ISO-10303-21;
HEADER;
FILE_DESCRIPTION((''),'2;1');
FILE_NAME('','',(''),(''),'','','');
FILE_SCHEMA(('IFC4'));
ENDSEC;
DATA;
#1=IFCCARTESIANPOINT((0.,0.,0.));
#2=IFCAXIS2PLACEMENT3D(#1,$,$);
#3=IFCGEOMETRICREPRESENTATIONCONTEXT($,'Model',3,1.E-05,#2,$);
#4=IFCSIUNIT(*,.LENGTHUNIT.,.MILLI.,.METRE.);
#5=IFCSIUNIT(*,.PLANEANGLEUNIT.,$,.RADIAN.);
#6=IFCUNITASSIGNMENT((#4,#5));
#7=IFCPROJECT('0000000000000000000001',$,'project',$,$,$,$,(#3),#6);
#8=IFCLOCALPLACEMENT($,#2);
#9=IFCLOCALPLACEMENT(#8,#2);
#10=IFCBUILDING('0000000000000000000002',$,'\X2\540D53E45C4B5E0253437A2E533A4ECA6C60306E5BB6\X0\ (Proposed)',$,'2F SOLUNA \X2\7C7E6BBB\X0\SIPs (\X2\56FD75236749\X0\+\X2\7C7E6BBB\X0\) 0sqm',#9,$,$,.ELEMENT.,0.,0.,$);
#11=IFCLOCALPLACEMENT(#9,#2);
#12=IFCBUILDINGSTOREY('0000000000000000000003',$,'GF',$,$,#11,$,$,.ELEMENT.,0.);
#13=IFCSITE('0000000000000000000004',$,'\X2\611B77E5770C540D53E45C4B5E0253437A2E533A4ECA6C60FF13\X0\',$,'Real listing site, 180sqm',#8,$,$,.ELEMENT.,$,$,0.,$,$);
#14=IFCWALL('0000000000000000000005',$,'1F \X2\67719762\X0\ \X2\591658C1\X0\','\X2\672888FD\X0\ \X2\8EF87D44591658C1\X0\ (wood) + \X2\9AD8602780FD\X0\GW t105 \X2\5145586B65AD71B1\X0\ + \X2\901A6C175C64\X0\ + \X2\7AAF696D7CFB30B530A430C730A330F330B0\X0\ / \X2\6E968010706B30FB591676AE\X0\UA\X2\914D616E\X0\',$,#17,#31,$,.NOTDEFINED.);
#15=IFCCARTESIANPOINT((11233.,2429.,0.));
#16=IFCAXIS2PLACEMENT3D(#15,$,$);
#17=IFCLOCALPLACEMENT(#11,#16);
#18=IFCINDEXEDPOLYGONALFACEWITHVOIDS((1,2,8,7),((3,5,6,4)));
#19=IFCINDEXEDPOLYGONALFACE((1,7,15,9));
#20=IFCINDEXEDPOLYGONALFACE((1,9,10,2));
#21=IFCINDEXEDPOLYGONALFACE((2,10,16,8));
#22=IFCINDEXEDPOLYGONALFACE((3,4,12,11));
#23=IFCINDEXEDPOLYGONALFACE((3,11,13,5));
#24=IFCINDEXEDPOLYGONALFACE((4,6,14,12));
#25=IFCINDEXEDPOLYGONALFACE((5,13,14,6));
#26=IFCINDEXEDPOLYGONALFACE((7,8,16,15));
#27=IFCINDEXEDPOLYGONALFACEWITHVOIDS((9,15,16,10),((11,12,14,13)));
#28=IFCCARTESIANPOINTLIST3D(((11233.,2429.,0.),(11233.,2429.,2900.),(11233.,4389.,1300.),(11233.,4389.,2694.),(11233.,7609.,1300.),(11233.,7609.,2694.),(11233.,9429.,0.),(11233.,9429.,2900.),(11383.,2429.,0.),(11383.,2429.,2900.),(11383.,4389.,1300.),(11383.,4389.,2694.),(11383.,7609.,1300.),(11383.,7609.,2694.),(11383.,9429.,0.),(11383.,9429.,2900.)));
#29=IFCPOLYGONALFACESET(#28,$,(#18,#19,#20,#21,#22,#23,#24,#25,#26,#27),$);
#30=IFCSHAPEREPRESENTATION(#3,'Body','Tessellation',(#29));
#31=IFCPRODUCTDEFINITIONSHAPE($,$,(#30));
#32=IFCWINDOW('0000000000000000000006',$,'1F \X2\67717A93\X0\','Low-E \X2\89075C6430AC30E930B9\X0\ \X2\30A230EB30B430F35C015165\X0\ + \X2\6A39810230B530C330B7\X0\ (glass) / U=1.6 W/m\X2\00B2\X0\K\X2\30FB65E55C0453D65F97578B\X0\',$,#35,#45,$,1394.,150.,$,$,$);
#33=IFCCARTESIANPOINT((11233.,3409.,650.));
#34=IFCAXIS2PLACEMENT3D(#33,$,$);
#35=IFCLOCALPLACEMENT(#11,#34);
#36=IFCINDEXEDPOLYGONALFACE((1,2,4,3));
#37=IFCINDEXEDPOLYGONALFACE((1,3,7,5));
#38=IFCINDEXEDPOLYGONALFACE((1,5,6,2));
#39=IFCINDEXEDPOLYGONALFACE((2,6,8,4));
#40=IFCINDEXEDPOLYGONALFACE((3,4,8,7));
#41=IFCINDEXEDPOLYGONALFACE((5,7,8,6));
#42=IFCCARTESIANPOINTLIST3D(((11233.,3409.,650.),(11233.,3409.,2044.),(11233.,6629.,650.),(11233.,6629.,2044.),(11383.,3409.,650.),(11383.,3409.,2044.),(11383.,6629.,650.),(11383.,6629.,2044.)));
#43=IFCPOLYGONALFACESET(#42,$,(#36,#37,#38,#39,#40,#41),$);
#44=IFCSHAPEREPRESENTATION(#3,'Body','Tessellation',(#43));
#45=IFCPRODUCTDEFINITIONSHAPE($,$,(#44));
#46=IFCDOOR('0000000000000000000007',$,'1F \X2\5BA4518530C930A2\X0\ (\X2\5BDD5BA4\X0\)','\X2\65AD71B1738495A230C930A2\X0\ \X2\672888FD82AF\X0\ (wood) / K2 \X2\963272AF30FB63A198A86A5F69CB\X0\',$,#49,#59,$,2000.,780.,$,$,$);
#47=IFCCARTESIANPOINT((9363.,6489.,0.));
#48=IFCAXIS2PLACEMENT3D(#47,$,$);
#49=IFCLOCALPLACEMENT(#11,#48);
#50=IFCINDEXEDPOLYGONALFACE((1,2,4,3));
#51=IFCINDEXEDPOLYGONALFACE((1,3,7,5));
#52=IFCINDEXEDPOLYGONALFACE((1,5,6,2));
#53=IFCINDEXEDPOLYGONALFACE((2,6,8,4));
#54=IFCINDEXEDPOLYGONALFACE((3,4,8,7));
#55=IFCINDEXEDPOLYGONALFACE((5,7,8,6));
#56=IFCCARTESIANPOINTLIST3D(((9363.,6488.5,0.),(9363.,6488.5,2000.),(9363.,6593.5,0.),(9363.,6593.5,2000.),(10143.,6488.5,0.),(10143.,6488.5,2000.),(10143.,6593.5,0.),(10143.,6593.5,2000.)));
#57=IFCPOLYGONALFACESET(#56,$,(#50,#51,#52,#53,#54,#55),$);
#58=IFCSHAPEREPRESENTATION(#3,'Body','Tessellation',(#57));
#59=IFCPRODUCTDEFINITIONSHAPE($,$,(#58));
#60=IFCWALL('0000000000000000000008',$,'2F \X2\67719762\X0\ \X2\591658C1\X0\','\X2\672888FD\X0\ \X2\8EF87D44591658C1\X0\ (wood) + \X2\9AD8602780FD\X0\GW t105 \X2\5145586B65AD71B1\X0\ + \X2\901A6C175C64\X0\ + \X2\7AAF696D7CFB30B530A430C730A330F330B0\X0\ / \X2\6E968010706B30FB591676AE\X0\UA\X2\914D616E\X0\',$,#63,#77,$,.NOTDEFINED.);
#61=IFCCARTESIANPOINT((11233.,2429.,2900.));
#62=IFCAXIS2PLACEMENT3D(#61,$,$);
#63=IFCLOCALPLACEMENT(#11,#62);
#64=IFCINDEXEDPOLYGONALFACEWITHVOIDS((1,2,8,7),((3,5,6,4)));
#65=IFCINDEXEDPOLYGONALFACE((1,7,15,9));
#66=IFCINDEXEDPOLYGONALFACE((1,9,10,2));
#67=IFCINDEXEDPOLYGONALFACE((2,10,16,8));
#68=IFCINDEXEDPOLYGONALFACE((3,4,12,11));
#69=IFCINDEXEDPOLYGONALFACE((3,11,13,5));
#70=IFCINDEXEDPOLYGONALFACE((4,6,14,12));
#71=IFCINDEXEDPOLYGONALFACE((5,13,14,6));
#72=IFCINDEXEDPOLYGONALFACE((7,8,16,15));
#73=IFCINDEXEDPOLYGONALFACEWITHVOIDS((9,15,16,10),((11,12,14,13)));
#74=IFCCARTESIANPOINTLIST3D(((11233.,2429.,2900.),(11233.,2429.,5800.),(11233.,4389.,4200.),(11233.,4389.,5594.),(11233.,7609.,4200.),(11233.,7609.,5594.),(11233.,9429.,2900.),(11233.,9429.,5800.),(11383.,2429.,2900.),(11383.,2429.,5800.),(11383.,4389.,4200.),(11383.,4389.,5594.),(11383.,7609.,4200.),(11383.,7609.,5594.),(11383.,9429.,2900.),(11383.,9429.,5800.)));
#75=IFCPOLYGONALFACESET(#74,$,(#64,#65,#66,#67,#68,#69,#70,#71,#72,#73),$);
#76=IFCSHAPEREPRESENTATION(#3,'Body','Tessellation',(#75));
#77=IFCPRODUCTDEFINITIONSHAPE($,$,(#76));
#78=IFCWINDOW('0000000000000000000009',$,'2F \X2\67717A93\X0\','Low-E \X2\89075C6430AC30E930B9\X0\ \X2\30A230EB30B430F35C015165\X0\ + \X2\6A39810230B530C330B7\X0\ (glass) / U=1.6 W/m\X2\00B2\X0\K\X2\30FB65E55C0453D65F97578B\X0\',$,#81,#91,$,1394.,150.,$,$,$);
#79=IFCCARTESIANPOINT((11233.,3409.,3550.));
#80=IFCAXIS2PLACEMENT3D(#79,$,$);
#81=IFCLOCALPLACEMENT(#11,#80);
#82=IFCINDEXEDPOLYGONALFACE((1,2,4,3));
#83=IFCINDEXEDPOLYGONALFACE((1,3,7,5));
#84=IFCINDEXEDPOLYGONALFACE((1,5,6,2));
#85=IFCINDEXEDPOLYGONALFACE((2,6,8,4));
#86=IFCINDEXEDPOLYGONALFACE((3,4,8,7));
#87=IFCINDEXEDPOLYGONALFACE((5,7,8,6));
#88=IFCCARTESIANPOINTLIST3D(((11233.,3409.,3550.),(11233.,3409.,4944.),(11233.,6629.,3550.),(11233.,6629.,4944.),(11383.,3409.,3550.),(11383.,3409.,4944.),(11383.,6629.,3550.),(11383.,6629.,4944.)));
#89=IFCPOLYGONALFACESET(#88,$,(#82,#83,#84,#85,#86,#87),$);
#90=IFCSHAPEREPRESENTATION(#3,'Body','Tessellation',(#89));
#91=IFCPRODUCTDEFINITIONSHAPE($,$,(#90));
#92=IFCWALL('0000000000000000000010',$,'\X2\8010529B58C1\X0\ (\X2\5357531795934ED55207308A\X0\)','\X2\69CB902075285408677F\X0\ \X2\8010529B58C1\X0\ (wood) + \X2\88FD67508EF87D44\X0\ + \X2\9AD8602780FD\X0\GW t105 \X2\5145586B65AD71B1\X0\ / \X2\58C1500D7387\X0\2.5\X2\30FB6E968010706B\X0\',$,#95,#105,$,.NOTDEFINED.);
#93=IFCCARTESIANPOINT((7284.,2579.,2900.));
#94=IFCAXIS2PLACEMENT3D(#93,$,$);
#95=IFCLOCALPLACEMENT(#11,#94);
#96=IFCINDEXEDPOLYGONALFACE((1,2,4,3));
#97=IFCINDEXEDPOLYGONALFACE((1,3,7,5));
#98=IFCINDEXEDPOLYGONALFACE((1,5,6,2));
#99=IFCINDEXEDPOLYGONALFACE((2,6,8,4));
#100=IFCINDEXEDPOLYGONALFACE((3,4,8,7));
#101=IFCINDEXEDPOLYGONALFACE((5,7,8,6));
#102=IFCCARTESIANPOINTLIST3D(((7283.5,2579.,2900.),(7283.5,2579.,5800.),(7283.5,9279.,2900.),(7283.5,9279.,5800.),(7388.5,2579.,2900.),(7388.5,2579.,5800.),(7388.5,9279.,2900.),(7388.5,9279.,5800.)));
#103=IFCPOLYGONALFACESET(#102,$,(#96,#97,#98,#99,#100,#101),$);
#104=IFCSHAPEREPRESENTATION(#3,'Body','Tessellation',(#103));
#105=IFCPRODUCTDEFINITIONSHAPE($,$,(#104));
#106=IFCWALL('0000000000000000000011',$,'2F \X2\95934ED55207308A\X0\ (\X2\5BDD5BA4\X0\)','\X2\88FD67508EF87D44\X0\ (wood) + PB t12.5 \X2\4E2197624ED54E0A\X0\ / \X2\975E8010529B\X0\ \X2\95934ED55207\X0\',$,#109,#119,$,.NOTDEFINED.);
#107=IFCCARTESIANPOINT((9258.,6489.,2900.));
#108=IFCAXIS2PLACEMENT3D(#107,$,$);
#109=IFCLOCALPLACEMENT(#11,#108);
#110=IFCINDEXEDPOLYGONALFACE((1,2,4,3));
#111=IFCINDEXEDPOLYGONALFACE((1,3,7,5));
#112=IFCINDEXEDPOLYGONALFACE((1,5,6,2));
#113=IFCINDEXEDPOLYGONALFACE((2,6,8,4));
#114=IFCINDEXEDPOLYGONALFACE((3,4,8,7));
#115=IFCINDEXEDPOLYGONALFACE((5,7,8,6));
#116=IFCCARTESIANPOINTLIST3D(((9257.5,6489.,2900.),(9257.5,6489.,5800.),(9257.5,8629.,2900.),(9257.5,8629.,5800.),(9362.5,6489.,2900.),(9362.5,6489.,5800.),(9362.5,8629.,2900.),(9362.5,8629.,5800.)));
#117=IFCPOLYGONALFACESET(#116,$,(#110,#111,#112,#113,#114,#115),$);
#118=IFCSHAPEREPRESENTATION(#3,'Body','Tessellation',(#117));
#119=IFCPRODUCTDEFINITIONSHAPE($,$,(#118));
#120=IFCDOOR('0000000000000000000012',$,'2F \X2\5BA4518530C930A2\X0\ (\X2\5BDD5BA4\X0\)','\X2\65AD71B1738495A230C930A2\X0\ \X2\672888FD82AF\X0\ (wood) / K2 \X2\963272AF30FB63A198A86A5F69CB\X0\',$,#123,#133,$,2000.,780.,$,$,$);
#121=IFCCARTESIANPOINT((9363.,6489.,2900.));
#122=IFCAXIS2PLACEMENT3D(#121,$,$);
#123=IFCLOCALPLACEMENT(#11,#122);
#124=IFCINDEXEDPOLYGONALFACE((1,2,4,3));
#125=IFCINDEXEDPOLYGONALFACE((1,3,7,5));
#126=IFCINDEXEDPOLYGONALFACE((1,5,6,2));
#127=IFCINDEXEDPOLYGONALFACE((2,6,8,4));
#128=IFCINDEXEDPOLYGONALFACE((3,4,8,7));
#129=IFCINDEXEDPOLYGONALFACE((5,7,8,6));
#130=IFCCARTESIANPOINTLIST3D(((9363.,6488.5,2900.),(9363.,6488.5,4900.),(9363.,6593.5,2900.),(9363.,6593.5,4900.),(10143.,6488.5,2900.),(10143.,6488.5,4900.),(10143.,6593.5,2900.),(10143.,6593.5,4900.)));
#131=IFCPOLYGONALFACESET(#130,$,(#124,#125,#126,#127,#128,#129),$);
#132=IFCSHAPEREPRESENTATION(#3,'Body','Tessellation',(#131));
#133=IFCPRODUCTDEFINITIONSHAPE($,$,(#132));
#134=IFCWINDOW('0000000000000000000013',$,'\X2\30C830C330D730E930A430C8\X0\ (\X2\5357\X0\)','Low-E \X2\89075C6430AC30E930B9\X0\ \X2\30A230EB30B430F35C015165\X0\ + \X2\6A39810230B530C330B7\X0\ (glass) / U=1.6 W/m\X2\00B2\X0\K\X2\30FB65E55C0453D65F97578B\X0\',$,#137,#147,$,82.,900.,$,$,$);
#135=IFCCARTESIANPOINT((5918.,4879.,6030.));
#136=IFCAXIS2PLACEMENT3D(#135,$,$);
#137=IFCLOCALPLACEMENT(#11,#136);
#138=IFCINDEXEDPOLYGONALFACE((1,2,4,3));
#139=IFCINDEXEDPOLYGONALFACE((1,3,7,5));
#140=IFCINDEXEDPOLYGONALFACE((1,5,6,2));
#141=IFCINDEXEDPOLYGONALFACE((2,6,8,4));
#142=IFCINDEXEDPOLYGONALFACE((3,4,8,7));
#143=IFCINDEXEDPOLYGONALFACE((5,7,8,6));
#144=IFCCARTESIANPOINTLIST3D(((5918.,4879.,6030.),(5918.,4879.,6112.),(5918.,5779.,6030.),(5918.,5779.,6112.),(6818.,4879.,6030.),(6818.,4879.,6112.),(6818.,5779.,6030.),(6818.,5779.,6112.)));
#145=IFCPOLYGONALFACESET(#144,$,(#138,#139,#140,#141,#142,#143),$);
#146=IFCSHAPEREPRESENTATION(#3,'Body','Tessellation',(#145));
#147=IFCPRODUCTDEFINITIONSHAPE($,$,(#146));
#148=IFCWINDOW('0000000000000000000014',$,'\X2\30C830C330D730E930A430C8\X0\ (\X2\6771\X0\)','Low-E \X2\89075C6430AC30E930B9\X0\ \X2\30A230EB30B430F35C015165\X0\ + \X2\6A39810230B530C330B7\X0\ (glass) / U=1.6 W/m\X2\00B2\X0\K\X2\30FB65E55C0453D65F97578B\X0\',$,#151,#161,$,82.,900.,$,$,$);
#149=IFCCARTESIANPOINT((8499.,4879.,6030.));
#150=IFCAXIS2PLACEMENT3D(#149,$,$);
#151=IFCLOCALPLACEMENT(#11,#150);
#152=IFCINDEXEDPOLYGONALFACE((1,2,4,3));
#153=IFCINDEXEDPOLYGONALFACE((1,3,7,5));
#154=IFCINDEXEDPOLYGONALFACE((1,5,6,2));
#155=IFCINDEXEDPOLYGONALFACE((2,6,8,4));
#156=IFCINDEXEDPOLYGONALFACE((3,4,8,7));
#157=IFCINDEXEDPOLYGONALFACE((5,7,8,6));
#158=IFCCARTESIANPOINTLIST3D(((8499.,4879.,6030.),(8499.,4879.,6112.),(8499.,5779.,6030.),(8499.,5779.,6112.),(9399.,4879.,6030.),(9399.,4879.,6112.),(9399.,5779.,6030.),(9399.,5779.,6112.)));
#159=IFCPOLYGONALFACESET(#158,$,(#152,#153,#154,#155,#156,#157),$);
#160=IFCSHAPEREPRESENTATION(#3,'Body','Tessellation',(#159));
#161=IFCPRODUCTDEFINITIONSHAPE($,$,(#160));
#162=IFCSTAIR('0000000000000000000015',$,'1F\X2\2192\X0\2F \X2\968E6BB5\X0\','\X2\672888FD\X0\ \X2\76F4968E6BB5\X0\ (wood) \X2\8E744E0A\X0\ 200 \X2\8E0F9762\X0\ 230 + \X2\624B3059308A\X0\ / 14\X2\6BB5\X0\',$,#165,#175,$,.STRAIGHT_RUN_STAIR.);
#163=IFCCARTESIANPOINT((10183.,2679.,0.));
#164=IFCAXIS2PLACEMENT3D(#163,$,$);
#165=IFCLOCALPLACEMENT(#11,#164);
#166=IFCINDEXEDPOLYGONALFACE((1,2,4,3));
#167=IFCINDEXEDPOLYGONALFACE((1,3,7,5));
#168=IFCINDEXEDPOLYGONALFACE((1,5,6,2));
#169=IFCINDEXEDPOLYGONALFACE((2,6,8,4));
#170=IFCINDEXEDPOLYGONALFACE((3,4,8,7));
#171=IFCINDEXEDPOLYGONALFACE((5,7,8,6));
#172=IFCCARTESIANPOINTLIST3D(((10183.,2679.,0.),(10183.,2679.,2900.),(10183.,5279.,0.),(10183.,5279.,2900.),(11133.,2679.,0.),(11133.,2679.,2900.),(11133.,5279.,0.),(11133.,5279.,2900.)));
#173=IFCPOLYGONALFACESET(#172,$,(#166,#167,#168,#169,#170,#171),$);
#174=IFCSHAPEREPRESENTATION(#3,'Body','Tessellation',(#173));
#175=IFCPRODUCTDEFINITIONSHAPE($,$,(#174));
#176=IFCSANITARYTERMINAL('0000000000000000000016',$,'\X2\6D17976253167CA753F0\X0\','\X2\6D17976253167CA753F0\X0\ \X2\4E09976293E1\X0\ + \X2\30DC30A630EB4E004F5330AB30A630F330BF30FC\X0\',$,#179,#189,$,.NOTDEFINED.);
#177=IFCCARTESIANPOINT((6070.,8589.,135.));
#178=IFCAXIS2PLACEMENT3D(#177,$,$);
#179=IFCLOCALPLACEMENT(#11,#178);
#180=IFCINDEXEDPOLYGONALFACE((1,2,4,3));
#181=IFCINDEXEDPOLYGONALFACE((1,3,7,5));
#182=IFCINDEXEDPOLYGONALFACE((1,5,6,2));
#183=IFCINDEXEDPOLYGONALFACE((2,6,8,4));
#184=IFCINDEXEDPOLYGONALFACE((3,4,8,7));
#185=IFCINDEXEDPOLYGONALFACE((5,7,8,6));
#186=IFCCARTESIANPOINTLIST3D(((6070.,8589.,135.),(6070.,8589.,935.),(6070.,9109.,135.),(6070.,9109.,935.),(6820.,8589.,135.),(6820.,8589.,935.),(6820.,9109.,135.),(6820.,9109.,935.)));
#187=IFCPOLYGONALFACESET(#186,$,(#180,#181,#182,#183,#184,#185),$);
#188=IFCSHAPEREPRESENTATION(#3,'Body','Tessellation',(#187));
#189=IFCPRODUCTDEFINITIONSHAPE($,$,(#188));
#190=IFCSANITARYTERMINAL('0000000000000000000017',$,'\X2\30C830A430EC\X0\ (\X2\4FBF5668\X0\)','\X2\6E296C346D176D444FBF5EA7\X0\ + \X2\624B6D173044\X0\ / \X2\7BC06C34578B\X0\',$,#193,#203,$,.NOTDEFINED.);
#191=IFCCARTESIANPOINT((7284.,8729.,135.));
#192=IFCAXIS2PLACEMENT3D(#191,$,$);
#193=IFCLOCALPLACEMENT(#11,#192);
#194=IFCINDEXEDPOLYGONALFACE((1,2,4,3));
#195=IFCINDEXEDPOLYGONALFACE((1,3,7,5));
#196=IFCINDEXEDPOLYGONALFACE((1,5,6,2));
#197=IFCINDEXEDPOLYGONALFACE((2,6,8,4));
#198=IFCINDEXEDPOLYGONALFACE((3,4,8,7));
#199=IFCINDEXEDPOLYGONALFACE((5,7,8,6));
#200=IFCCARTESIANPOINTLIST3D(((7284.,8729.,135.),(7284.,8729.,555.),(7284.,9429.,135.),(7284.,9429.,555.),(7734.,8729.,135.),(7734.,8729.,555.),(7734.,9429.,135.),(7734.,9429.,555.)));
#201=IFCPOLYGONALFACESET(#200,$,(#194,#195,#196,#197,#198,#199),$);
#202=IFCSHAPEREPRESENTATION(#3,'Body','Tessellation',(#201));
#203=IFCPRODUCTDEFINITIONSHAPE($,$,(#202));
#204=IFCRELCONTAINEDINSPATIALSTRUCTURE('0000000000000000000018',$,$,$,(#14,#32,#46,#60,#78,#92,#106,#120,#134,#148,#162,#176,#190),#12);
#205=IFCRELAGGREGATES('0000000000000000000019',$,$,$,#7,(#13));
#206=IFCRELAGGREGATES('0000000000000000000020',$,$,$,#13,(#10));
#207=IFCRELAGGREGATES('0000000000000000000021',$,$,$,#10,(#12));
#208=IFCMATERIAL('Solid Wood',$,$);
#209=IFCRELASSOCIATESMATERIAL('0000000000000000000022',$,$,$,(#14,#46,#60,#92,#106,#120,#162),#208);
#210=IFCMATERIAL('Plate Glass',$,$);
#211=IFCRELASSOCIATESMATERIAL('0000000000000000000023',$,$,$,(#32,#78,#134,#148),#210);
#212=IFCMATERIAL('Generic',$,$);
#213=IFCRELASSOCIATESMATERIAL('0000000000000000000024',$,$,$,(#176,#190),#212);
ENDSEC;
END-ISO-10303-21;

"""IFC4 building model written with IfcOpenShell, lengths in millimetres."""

from ifc_helpers import new_model, si_unit, frame, frame_2d, origin, place, context, project, spatial, rectangle, extrude, material, element, fill, save


model = new_model("IFC4")

# Units and contexts
model_context = context("Model", 3, precision=1e-05, world=origin())
ifc_project = project(units=[si_unit("LENGTHUNIT", "METRE", prefix="MILLI"), si_unit("PLANEANGLEUNIT", "RADIAN")], contexts=[model_context])

# Site, building, storey
site_placement = place(None, origin())
site = spatial("IfcSite", under=ifc_project, at=site_placement, Name="愛知県名古屋市千種区今池３", ObjectType="Real listing site, 180sqm", CompositionType="ELEMENT", RefElevation=0.0)
building_placement = place(site_placement, origin())
building = spatial("IfcBuilding", under=site, at=building_placement, Name="名古屋市千種区今池の家 (Proposed)", ObjectType="2F SOLUNA 籾殻SIPs (国産杉+籾殻) 0sqm", CompositionType="ELEMENT", ElevationOfRefHeight=0.0, ElevationOfTerrain=0.0)
storey_placement = place(building_placement, origin())
storey = spatial("IfcBuildingStorey", under=building, at=storey_placement, Name="GF", CompositionType="ELEMENT", Elevation=0.0)

# Wall, opening, window
ifc_material_1 = material(Name="Solid Wood")
wall_1_placement = place(storey_placement, frame((11233.0, 2429.0, 0.0)))
wall_1 = element("IfcWall", 1, at=wall_1_placement, inside=storey, material=ifc_material_1, Name="1F 東面 外壁", Description="木製 軸組外壁 (wood) + 高性能GW t105 充填断熱 + 通気層 + 窯業系サイディング / 準耐火・外皮UA配慮", PredefinedType="NOTDEFINED", context=model_context, shape_type="SweptSolid", body=[
    extrude(rectangle(XDim=150.0, YDim=7000.0, at=frame_2d((75.0, 3500.0))), frame((11233.0, 2429.0, 0.0)), (0.0, 0.0, 1.0), 2900.0),
])
opening_1_placement = place(storey_placement, frame((11233.0, 3409.0, 650.0)))
opening_1 = element("IfcOpeningElement", 2, at=opening_1_placement, cuts=wall_1, PredefinedType="NOTDEFINED", context=model_context, shape_type="SweptSolid", body=[
    extrude(rectangle(XDim=150.0, YDim=3220.0, at=frame_2d((75.0, 1610.0))), frame((11233.0, 3409.0, 650.0)), (0.0, 0.0, 1.0), 1394.0),
])
ifc_material_2 = material(Name="Plate Glass")
window_1_placement = place(storey_placement, frame((11233.0, 3409.0, 650.0)))
window_1 = element("IfcWindow", 3, at=window_1_placement, inside=storey, material=ifc_material_2, Name="1F 東窓", Description="Low-E 複層ガラス アルゴン封入 + 樹脂サッシ (glass) / U=1.6 W/m²K・日射取得型", OverallHeight=1394.0, OverallWidth=150.0, context=model_context, shape_type="SweptSolid", body=[
    extrude(rectangle(XDim=150.0, YDim=3220.0, at=frame_2d((75.0, 1610.0))), frame((11233.0, 3409.0, 650.0)), (0.0, 0.0, 1.0), 1394.0),
])
fill(opening_1, window_1)

# Door
door_1_placement = place(storey_placement, frame((9363.0, 6489.0, 0.0)))
element("IfcDoor", 4, at=door_1_placement, inside=storey, material=ifc_material_1, Name="1F 室内ドア (寝室)", Description="断熱玄関ドア 木製芯 (wood) / K2 防犯・採風機構", OverallHeight=2000.0, OverallWidth=780.0, context=model_context, shape_type="SweptSolid", body=[
    extrude(rectangle(XDim=780.0, YDim=105.0, at=frame_2d((390.0, 52.0))), frame((9363.0, 6489.0, 0.0)), (0.0, 0.0, 1.0), 2000.0),
])

# Wall, opening, window
wall_2_placement = place(storey_placement, frame((11233.0, 2429.0, 2900.0)))
wall_2 = element("IfcWall", 5, at=wall_2_placement, inside=storey, material=ifc_material_1, Name="2F 東面 外壁", Description="木製 軸組外壁 (wood) + 高性能GW t105 充填断熱 + 通気層 + 窯業系サイディング / 準耐火・外皮UA配慮", PredefinedType="NOTDEFINED", context=model_context, shape_type="SweptSolid", body=[
    extrude(rectangle(XDim=150.0, YDim=7000.0, at=frame_2d((75.0, 3500.0))), frame((11233.0, 2429.0, 2900.0)), (0.0, 0.0, 1.0), 2900.0),
])
opening_2_placement = place(storey_placement, frame((11233.0, 3409.0, 3550.0)))
opening_2 = element("IfcOpeningElement", 6, at=opening_2_placement, cuts=wall_2, PredefinedType="NOTDEFINED", context=model_context, shape_type="SweptSolid", body=[
    extrude(rectangle(XDim=150.0, YDim=3220.0, at=frame_2d((75.0, 1610.0))), frame((11233.0, 3409.0, 3550.0)), (0.0, 0.0, 1.0), 1394.0),
])
window_2_placement = place(storey_placement, frame((11233.0, 3409.0, 3550.0)))
window_2 = element("IfcWindow", 7, at=window_2_placement, inside=storey, material=ifc_material_2, Name="2F 東窓", Description="Low-E 複層ガラス アルゴン封入 + 樹脂サッシ (glass) / U=1.6 W/m²K・日射取得型", OverallHeight=1394.0, OverallWidth=150.0, context=model_context, shape_type="SweptSolid", body=[
    extrude(rectangle(XDim=150.0, YDim=3220.0, at=frame_2d((75.0, 1610.0))), frame((11233.0, 3409.0, 3550.0)), (0.0, 0.0, 1.0), 1394.0),
])
fill(opening_2, window_2)

# Walls
wall_3_placement = place(storey_placement, frame((7284.0, 2579.0, 2900.0)))
element("IfcWall", 8, at=wall_3_placement, inside=storey, material=ifc_material_1, Name="耐力壁 (南北間仕切り)", Description="構造用合板 耐力壁 (wood) + 製材軸組 + 高性能GW t105 充填断熱 / 壁倍率2.5・準耐火", PredefinedType="NOTDEFINED", context=model_context, shape_type="SweptSolid", body=[
    extrude(rectangle(XDim=105.0, YDim=6700.0, at=frame_2d((52.0, 3350.0))), frame((7284.0, 2579.0, 2900.0)), (0.0, 0.0, 1.0), 2900.0),
])
wall_4_placement = place(storey_placement, frame((9258.0, 6489.0, 2900.0)))
element("IfcWall", 9, at=wall_4_placement, inside=storey, material=ifc_material_1, Name="2F 間仕切り (寝室)", Description="製材軸組 (wood) + PB t12.5 両面仕上 / 非耐力 間仕切", PredefinedType="NOTDEFINED", context=model_context, shape_type="SweptSolid", body=[
    extrude(rectangle(XDim=105.0, YDim=2140.0, at=frame_2d((52.0, 1070.0))), frame((9258.0, 6489.0, 2900.0)), (0.0, 0.0, 1.0), 2900.0),
])

# Door
door_2_placement = place(storey_placement, frame((9363.0, 6489.0, 2900.0)))
element("IfcDoor", 10, at=door_2_placement, inside=storey, material=ifc_material_1, Name="2F 室内ドア (寝室)", Description="断熱玄関ドア 木製芯 (wood) / K2 防犯・採風機構", OverallHeight=2000.0, OverallWidth=780.0, context=model_context, shape_type="SweptSolid", body=[
    extrude(rectangle(XDim=780.0, YDim=105.0, at=frame_2d((390.0, 52.0))), frame((9363.0, 6489.0, 2900.0)), (0.0, 0.0, 1.0), 2000.0),
])

# Windows
window_3_placement = place(storey_placement, frame((5918.0, 4879.0, 6030.0)))
element("IfcWindow", 11, at=window_3_placement, inside=storey, material=ifc_material_2, Name="トップライト (南)", Description="Low-E 複層ガラス アルゴン封入 + 樹脂サッシ (glass) / U=1.6 W/m²K・日射取得型", OverallHeight=82.0, OverallWidth=900.0, context=model_context, shape_type="SweptSolid", body=[
    extrude(rectangle(XDim=900.0, YDim=900.0, at=frame_2d((450.0, 450.0))), frame((5918.0, 4879.0, 6030.0)), (0.0, 0.0, 1.0), 82.0),
])
window_4_placement = place(storey_placement, frame((8499.0, 4879.0, 6030.0)))
element("IfcWindow", 12, at=window_4_placement, inside=storey, material=ifc_material_2, Name="トップライト (東)", Description="Low-E 複層ガラス アルゴン封入 + 樹脂サッシ (glass) / U=1.6 W/m²K・日射取得型", OverallHeight=82.0, OverallWidth=900.0, context=model_context, shape_type="SweptSolid", body=[
    extrude(rectangle(XDim=900.0, YDim=900.0, at=frame_2d((450.0, 450.0))), frame((8499.0, 4879.0, 6030.0)), (0.0, 0.0, 1.0), 82.0),
])

# Stair
stair_placement = place(storey_placement, frame((10183.0, 2679.0, 0.0)))
element("IfcStair", 13, at=stair_placement, inside=storey, material=ifc_material_1, Name="1F→2F 階段", Description="木製 直階段 (wood) 蹴上 200 踏面 230 + 手すり / 14段", PredefinedType="STRAIGHT_RUN_STAIR", context=model_context, shape_type="SweptSolid", body=[
    extrude(rectangle(XDim=950.0, YDim=2600.0, at=frame_2d((475.0, 1300.0))), frame((10183.0, 2679.0, 0.0)), (0.0, 0.0, 1.0), 2900.0),
])

# Sanitary terminals
ifc_material_3 = material(Name="Generic")
sanitary_terminal_1_placement = place(storey_placement, frame((6070.0, 8589.0, 135.0)))
element("IfcSanitaryTerminal", 14, at=sanitary_terminal_1_placement, inside=storey, material=ifc_material_3, Name="洗面化粧台", Description="洗面化粧台 三面鏡 + ボウル一体カウンター", PredefinedType="NOTDEFINED", context=model_context, shape_type="SweptSolid", body=[
    extrude(rectangle(XDim=750.0, YDim=520.0, at=frame_2d((375.0, 260.0))), frame((6070.0, 8589.0, 135.0)), (0.0, 0.0, 1.0), 800.0),
])
sanitary_terminal_2_placement = place(storey_placement, frame((7284.0, 8729.0, 135.0)))
element("IfcSanitaryTerminal", 15, at=sanitary_terminal_2_placement, inside=storey, material=ifc_material_3, Name="トイレ (便器)", Description="温水洗浄便座 + 手洗い / 節水型", PredefinedType="NOTDEFINED", context=model_context, shape_type="SweptSolid", body=[
    extrude(rectangle(XDim=450.0, YDim=700.0, at=frame_2d((225.0, 350.0))), frame((7284.0, 8729.0, 135.0)), (0.0, 0.0, 1.0), 420.0),
])

save(model, "model.ifc")
